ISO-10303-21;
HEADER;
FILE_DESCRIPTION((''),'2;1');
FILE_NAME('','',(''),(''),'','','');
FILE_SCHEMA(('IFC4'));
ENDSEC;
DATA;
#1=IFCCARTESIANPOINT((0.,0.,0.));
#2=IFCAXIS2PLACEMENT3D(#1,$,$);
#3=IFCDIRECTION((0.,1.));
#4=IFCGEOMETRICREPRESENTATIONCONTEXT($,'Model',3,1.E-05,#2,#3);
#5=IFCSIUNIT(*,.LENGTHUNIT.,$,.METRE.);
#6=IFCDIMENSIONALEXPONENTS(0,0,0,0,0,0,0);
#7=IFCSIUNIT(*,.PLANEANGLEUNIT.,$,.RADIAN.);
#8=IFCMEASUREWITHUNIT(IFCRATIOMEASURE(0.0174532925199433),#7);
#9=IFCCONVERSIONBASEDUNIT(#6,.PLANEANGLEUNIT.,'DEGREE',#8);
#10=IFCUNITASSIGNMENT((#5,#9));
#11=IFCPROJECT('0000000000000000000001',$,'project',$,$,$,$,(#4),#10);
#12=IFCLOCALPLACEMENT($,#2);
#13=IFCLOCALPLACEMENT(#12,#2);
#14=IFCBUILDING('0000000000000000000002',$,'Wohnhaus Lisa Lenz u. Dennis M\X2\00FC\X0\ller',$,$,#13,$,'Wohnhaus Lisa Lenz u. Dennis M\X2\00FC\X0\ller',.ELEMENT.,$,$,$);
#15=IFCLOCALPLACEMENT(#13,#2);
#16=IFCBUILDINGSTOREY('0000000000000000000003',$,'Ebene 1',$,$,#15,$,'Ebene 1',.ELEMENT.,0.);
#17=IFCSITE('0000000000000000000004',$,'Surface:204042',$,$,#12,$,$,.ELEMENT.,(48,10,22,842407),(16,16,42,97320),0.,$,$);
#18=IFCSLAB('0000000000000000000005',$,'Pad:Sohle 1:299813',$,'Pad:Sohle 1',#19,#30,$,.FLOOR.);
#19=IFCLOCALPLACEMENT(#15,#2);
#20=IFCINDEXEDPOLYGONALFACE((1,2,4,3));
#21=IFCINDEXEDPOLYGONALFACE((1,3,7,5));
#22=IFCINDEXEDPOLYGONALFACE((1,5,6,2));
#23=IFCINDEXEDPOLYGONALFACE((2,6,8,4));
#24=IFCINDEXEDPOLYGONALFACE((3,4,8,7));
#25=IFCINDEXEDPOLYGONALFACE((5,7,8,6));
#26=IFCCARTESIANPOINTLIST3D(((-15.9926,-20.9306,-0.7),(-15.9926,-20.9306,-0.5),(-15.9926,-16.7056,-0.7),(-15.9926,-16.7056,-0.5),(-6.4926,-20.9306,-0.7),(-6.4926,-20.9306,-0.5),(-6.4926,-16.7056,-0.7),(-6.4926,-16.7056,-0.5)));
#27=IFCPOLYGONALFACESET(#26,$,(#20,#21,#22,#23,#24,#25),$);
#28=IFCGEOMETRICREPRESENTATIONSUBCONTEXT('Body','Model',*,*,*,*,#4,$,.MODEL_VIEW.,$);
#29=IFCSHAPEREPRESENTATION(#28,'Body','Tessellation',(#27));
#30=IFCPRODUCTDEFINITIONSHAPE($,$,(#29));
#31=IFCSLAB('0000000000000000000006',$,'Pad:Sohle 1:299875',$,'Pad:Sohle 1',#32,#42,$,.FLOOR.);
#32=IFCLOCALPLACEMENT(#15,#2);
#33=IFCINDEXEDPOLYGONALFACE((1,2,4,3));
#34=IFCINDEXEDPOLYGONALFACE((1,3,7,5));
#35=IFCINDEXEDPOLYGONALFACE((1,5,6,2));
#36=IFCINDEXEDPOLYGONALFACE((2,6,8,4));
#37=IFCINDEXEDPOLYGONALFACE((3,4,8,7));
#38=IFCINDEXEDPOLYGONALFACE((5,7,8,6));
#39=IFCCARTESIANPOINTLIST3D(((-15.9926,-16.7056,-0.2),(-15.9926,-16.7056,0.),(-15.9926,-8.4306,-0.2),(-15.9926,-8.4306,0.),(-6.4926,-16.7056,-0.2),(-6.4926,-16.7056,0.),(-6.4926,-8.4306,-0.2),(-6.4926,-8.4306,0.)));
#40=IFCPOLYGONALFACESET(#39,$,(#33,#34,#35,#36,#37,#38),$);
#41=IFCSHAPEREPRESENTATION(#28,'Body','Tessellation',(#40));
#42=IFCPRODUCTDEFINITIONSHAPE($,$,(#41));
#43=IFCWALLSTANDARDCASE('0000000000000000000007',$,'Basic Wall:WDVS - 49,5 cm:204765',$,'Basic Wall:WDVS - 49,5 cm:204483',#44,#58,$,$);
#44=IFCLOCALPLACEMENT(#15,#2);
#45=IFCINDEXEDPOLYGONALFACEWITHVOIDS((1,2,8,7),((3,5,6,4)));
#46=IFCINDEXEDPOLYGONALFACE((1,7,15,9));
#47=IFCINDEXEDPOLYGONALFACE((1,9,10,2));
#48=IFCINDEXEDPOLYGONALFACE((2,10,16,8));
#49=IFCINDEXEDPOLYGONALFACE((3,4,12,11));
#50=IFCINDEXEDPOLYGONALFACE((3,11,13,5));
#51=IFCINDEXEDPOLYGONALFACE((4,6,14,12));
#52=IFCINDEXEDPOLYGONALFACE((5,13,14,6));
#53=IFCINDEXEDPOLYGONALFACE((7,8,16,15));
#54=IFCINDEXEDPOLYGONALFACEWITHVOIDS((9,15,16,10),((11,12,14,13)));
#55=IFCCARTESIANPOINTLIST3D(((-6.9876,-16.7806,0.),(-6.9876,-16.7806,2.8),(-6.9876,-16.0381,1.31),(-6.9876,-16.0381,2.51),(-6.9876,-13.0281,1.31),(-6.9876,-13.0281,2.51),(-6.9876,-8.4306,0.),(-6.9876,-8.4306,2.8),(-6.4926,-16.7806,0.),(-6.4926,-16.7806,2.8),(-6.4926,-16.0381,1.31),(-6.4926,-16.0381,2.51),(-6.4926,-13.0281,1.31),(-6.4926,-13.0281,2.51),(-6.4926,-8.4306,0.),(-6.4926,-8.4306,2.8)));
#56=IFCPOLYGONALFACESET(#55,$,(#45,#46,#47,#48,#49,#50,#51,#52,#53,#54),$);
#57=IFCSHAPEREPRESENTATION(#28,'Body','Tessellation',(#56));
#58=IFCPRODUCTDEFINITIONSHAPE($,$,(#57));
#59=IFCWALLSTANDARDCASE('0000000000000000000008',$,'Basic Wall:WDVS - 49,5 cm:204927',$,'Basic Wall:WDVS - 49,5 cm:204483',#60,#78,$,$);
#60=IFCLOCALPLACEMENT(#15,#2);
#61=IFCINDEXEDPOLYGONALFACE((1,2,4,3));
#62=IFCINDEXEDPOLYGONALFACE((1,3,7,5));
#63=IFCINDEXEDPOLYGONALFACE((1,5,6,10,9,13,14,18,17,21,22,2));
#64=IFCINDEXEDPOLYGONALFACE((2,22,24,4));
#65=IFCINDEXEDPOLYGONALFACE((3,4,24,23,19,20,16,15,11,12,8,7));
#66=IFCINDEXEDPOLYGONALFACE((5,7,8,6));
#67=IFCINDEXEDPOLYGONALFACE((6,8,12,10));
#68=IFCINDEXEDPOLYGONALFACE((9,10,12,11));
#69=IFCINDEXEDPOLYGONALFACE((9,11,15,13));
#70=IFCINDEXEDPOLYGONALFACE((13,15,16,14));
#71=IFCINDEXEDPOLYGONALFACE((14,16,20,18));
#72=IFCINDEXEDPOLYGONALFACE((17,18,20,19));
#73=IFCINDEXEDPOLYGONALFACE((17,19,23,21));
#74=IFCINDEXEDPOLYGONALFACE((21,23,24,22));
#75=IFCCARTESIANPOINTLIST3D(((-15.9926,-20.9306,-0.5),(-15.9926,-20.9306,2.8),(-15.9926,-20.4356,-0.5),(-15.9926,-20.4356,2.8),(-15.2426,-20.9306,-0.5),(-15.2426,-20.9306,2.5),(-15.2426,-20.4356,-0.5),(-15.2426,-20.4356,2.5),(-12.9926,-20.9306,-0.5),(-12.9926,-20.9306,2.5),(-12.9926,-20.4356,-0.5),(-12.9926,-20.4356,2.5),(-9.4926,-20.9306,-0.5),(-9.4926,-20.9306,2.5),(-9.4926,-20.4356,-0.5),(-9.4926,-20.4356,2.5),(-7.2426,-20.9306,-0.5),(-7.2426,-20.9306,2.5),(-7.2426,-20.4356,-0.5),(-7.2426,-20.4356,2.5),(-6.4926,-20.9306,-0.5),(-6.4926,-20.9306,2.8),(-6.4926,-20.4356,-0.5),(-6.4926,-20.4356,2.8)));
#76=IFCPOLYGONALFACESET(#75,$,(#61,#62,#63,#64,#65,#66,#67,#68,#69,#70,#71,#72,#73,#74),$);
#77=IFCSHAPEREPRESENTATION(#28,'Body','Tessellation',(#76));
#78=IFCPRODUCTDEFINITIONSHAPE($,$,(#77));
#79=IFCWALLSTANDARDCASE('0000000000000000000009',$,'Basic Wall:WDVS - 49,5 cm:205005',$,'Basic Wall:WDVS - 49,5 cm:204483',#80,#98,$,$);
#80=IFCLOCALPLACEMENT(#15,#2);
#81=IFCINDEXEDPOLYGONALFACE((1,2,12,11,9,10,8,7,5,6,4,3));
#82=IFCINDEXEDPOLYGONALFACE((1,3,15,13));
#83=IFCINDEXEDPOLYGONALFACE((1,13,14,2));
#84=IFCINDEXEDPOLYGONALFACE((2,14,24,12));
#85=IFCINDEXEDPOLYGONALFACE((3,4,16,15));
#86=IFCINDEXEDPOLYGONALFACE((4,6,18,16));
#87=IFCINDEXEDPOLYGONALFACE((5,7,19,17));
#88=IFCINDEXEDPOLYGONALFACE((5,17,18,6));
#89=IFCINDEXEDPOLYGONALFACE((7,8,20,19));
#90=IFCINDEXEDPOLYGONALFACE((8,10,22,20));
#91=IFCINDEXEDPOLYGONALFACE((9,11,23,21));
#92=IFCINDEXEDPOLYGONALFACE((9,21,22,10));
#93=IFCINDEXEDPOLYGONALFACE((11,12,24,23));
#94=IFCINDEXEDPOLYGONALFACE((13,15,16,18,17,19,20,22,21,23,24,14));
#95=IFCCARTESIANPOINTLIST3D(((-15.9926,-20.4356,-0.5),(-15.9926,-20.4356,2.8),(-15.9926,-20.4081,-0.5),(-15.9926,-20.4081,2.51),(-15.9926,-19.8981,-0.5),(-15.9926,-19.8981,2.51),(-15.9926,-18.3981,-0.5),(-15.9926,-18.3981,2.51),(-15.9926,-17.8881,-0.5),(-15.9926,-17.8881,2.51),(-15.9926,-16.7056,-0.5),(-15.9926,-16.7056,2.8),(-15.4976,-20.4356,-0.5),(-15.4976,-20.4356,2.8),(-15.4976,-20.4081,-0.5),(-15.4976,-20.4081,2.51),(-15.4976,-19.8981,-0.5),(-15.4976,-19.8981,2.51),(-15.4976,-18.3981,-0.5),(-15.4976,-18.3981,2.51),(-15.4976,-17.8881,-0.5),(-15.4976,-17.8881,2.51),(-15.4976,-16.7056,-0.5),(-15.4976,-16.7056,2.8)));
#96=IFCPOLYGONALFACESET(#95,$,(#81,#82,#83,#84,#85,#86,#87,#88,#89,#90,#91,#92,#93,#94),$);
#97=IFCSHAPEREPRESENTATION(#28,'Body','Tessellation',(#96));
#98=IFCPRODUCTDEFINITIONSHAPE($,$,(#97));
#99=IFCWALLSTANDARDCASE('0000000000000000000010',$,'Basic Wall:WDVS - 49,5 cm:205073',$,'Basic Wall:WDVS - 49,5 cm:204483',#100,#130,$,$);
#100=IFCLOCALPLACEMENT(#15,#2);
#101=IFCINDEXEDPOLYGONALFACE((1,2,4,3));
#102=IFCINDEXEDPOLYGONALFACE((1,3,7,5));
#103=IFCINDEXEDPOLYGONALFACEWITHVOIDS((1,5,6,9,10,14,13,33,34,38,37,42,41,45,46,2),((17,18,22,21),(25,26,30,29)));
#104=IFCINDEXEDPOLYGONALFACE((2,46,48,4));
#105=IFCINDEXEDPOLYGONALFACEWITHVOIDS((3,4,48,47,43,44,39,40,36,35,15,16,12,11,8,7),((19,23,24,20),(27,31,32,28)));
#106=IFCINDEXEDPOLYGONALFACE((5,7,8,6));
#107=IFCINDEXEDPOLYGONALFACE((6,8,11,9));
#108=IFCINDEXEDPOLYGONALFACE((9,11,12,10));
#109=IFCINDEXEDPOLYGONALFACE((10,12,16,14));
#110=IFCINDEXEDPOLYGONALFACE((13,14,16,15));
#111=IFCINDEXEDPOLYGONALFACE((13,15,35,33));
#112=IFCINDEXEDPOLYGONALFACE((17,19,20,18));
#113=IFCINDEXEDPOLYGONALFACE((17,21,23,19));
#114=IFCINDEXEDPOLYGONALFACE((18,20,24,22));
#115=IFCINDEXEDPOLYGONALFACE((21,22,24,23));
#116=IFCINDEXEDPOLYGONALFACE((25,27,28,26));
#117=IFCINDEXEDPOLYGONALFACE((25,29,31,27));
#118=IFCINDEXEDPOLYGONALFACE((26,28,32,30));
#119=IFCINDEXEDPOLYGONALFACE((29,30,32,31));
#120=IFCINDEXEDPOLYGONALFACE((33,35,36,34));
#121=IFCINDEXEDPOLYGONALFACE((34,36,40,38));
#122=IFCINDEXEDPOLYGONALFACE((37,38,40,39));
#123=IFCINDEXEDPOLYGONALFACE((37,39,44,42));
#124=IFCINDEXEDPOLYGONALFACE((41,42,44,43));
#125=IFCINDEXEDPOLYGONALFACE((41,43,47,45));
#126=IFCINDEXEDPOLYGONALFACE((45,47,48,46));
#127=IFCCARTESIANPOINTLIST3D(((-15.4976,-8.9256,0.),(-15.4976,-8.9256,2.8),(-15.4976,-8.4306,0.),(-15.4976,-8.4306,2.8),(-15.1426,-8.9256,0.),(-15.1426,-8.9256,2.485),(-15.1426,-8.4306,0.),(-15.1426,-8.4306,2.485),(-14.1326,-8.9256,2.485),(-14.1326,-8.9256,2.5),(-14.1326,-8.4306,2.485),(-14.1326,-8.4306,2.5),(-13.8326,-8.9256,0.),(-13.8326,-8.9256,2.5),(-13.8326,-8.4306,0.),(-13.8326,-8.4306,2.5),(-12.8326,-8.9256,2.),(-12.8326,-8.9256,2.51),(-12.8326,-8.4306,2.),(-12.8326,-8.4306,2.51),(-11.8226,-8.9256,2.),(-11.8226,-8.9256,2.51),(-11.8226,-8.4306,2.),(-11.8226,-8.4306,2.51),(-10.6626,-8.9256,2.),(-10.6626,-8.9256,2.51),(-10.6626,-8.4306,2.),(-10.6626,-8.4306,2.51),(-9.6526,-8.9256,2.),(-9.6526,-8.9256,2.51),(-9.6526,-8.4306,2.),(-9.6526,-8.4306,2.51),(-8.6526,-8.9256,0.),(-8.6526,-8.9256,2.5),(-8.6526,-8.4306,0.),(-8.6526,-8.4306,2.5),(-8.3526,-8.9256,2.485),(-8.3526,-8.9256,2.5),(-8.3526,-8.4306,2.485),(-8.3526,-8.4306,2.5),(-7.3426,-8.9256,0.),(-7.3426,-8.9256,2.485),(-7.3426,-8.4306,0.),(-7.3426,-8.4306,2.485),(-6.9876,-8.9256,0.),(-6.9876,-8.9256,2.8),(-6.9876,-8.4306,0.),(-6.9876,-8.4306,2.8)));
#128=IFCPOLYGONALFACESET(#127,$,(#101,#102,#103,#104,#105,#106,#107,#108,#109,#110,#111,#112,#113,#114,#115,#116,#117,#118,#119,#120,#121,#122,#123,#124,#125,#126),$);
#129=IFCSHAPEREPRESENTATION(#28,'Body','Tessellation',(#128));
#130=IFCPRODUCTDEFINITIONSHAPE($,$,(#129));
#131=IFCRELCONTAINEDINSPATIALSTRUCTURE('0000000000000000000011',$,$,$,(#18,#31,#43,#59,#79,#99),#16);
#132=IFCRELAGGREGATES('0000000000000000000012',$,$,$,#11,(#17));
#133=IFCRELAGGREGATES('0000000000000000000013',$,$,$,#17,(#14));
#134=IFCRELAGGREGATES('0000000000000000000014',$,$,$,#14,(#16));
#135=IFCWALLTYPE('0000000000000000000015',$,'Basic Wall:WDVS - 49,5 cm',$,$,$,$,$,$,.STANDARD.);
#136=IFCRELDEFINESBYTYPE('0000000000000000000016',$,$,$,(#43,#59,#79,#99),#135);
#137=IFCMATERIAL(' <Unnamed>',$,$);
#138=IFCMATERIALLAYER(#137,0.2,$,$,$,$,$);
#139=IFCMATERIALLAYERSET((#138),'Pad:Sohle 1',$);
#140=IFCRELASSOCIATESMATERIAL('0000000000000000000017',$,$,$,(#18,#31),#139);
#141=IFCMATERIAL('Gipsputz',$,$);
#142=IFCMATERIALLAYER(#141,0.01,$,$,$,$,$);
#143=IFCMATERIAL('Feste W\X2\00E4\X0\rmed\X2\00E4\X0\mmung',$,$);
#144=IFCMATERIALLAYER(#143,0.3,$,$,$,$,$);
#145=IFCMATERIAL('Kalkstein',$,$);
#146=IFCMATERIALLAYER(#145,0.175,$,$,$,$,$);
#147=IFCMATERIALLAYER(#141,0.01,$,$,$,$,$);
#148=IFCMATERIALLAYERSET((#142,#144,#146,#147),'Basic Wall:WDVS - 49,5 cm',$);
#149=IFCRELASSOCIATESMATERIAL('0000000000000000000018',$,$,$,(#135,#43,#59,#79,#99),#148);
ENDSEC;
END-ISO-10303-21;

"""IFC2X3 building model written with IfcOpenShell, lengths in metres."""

from ifc_helpers import new_model, entity, si_unit, converted_unit, direction, frame, frame_2d, origin, place, context, subcontext, project, spatial, polyline, rectangle, extrude, clip, bounded_halfspace, material, layer, layer_set, layer_usage, type_object, element, save


model = new_model("IFC2X3")

# Units and contexts
model_context = context("Model", 3, precision=1e-05, world=origin(), true_north=direction((0.0, 1.0)))
body_context = subcontext(model_context, "Body", "Model", "MODEL_VIEW")
ifc_project = project(units=[si_unit("LENGTHUNIT", "METRE"), converted_unit("PLANEANGLEUNIT", "DEGREE", entity("IfcRatioMeasure", 0.0174532925199433), si_unit("PLANEANGLEUNIT", "RADIAN"), dimensions=[0, 0, 0, 0, 0, 0, 0])], contexts=[model_context])

# Site, building, storey
site_placement = place(None, origin())
site = spatial("IfcSite", under=ifc_project, at=site_placement, Name="Surface:204042", CompositionType="ELEMENT", RefLatitude=(48, 10, 22, 842407), RefLongitude=(16, 16, 42, 97320), RefElevation=0.0)
building_placement = place(site_placement, origin())
building = spatial("IfcBuilding", under=site, at=building_placement, Name="Wohnhaus Lisa Lenz u. Dennis Müller", LongName="Wohnhaus Lisa Lenz u. Dennis Müller", CompositionType="ELEMENT")
storey_placement = place(building_placement, origin())
storey = spatial("IfcBuildingStorey", under=building, at=storey_placement, Name="Ebene 1", LongName="Ebene 1", CompositionType="ELEMENT", Elevation=0.0)

# Slabs
ifc_material_1 = material(Name=" <Unnamed>")
ifc_layer_1 = layer(ifc_material_1, 0.2)
ifc_layer_set_1 = layer_set([ifc_layer_1], Name="Pad:Sohle 1")
ifc_layer_usage_1 = layer_usage(ifc_layer_set_1, "AXIS3", "POSITIVE", 0.0)
slab_1_placement = place(storey_placement, origin())
element("IfcSlab", 1, at=slab_1_placement, inside=storey, material=ifc_layer_usage_1, Name="Pad:Sohle 1:299813", ObjectType="Pad:Sohle 1", PredefinedType="FLOOR", context=body_context, shape_type="SweptSolid", body=[
    extrude(rectangle(XDim=9.5, YDim=4.225, at=frame_2d((0.0, 0.0), x_axis=(1.0, 0.0))), frame((-11.2426, -18.8181, -0.7), z_axis=(0.0, 0.0, 1.0), x_axis=(-1.0, 0.0, 0.0)), (0.0, 0.0, 1.0), 0.2),
])
ifc_layer_usage_2 = layer_usage(ifc_layer_set_1, "AXIS3", "POSITIVE", 0.0)
slab_2_placement = place(storey_placement, origin())
element("IfcSlab", 2, at=slab_2_placement, inside=storey, material=ifc_layer_usage_2, Name="Pad:Sohle 1:299875", ObjectType="Pad:Sohle 1", PredefinedType="FLOOR", context=body_context, shape_type="SweptSolid", body=[
    extrude(rectangle(XDim=9.5, YDim=8.275, at=frame_2d((0.0, 0.0), x_axis=(1.0, 0.0))), frame((-11.2426, -12.5681, -0.2), z_axis=(0.0, 0.0, 1.0), x_axis=(-1.0, 0.0, 0.0)), (0.0, 0.0, 1.0), 0.2),
])

# Wall, opening
ifc_material_2 = material(Name="Gipsputz")
ifc_layer_2 = layer(ifc_material_2, 0.01)
ifc_material_3 = material(Name="Feste Wärmedämmung")
ifc_layer_3 = layer(ifc_material_3, 0.3)
ifc_material_4 = material(Name="Kalkstein")
ifc_layer_4 = layer(ifc_material_4, 0.175)
ifc_layer_5 = layer(ifc_material_2, 0.01)
ifc_layer_set_2 = layer_set([ifc_layer_2, ifc_layer_3, ifc_layer_4, ifc_layer_5], Name="Basic Wall:WDVS - 49,5 cm")
ifc_layer_usage_3 = layer_usage(ifc_layer_set_2, "AXIS2", "NEGATIVE", 0.2475)
wall_type_1 = type_object("IfcWallType", Name="Basic Wall:WDVS - 49,5 cm", PredefinedType="STANDARD", material=ifc_layer_set_2)
wall_1_placement = place(storey_placement, frame((-6.7401, -8.4306, 0.0), z_axis=(0.0, 0.0, 1.0), x_axis=(0.0, -1.0, 0.0)))
wall_1 = element("IfcWallStandardCase", 3, at=wall_1_placement, inside=storey, type_object=wall_type_1, material=ifc_layer_usage_3, Name="Basic Wall:WDVS - 49,5 cm:204765", ObjectType="Basic Wall:WDVS - 49,5 cm:204483", context=body_context, shape_type="Clipping", body=[
    clip(extrude(rectangle(XDim=8.35, YDim=0.495, at=frame_2d((4.175, 0.0), x_axis=(-1.0, 0.0))), origin(), (0.0, 0.0, 1.0), 2.8), bounded_halfspace(frame((0.0, -0.2475, 2.8), z_axis=(0.0, 0.0, -1.0), x_axis=(0.0, -1.0, 0.0)), True, frame((0.0, -0.2475, 2.8)), polyline([(0.0, 0.0), (0.495, 0.0), (8.35, 0.0), (8.35, 0.495), (0.0, 0.495), (0.0, 0.0)]))),
])
opening_1_placement = place(wall_1_placement, frame((7.6075, 0.2475, 1.31)))
element("IfcOpeningElement", 4, at=opening_1_placement, cuts=wall_1, ObjectType="Opening", context=body_context, shape_type="SweptSolid", body=[
    extrude(rectangle(XDim=1.2, YDim=3.01, at=frame_2d((0.6, 1.505), x_axis=(1.0, 0.0))), frame((0.0, 0.0, 0.0), z_axis=(0.0, -1.0, 0.0), x_axis=(0.0, 0.0, 1.0)), (0.0, 0.0, 1.0), 0.495),
])

# Walls, openings
ifc_layer_usage_4 = layer_usage(ifc_layer_set_2, "AXIS2", "NEGATIVE", 0.2475)
wall_2_placement = place(storey_placement, frame((-6.4926, -20.6831, -0.5), z_axis=(0.0, 0.0, 1.0), x_axis=(-1.0, 0.0, 0.0)))
wall_2 = element("IfcWallStandardCase", 5, at=wall_2_placement, inside=storey, type_object=wall_type_1, material=ifc_layer_usage_4, Name="Basic Wall:WDVS - 49,5 cm:204927", ObjectType="Basic Wall:WDVS - 49,5 cm:204483", context=body_context, shape_type="Clipping", body=[
    clip(extrude(rectangle(XDim=9.5, YDim=0.495, at=frame_2d((4.75, 0.0), x_axis=(-1.0, 0.0))), origin(), (0.0, 0.0, 1.0), 3.3), bounded_halfspace(frame((0.0, -0.2475, 3.3), z_axis=(0.0, 0.0, -1.0), x_axis=(1.0, 0.0, 0.0)), True, frame((0.0, -0.2475, 3.3)), polyline([(0.0, 0.0), (0.495, 0.0), (4.5, 0.0), (5.0, 0.0), (9.005, 0.0), (9.5, 0.0), (9.5, 0.495), (0.0, 0.495), (0.0, 0.0)]))),
])
opening_2_placement = place(wall_2_placement, frame((8.75, 0.2475, 0.0)))
element("IfcOpeningElement", 6, at=opening_2_placement, cuts=wall_2, ObjectType="Opening", context=body_context, shape_type="SweptSolid", body=[
    extrude(rectangle(XDim=3.0, YDim=2.25, at=frame_2d((1.5, 1.125), x_axis=(1.0, 0.0))), frame((0.0, 0.0, 0.0), z_axis=(0.0, -1.0, 0.0), x_axis=(0.0, 0.0, 1.0)), (0.0, 0.0, 1.0), 0.495),
])
opening_3_placement = place(wall_2_placement, frame((3.0, 0.2475, 0.0)))
element("IfcOpeningElement", 7, at=opening_3_placement, cuts=wall_2, ObjectType="Opening", context=body_context, shape_type="SweptSolid", body=[
    extrude(rectangle(XDim=3.0, YDim=2.25, at=frame_2d((1.5, 1.125), x_axis=(1.0, 0.0))), frame((0.0, 0.0, 0.0), z_axis=(0.0, -1.0, 0.0), x_axis=(0.0, 0.0, 1.0)), (0.0, 0.0, 1.0), 0.495),
])
ifc_layer_usage_5 = layer_usage(ifc_layer_set_2, "AXIS2", "NEGATIVE", 0.2475)
wall_3_placement = place(storey_placement, frame((-15.7451, -20.4356, -0.5), z_axis=(0.0, 0.0, 1.0), x_axis=(0.0, 1.0, 0.0)))
wall_3 = element("IfcWallStandardCase", 8, at=wall_3_placement, inside=storey, type_object=wall_type_1, material=ifc_layer_usage_5, Name="Basic Wall:WDVS - 49,5 cm:205005", ObjectType="Basic Wall:WDVS - 49,5 cm:204483", context=body_context, shape_type="Clipping", body=[
    clip(extrude(rectangle(XDim=3.73, YDim=0.495, at=frame_2d((1.865, 0.0), x_axis=(-1.0, 0.0))), origin(), (0.0, 0.0, 1.0), 3.3), bounded_halfspace(frame((0.0, -0.2475, 3.3), z_axis=(0.0, 0.0, -1.0), x_axis=(0.0, 1.0, 0.0)), True, frame((0.0, -0.2475, 3.3)), polyline([(0.0, 0.0), (3.655, 0.0), (3.655, 0.495), (0.0, 0.495), (0.0, 0.0)]))),
])
opening_4_placement = place(wall_3_placement, frame((2.5475, 0.2475, 0.0)))
element("IfcOpeningElement", 9, at=opening_4_placement, cuts=wall_3, ObjectType="Opening", context=body_context, shape_type="SweptSolid", body=[
    extrude(rectangle(XDim=3.01, YDim=0.51, at=frame_2d((1.505, 0.255), x_axis=(1.0, 0.0))), frame((0.0, 0.0, 0.0), z_axis=(0.0, -1.0, 0.0), x_axis=(0.0, 0.0, 1.0)), (0.0, 0.0, 1.0), 0.495),
])
opening_5_placement = place(wall_3_placement, frame((0.5375, 0.2475, 0.0)))
element("IfcOpeningElement", 10, at=opening_5_placement, cuts=wall_3, ObjectType="Opening", context=body_context, shape_type="SweptSolid", body=[
    extrude(rectangle(XDim=3.01, YDim=0.51, at=frame_2d((1.505, 0.255), x_axis=(1.0, 0.0))), frame((0.0, 0.0, 0.0), z_axis=(0.0, -1.0, 0.0), x_axis=(0.0, 0.0, 1.0)), (0.0, 0.0, 1.0), 0.495),
])
ifc_layer_usage_6 = layer_usage(ifc_layer_set_2, "AXIS2", "NEGATIVE", 0.2475)
wall_4_placement = place(storey_placement, frame((-15.4976, -8.6781, 0.0)))
wall_4 = element("IfcWallStandardCase", 11, at=wall_4_placement, inside=storey, type_object=wall_type_1, material=ifc_layer_usage_6, Name="Basic Wall:WDVS - 49,5 cm:205073", ObjectType="Basic Wall:WDVS - 49,5 cm:204483", context=body_context, shape_type="Clipping", body=[
    clip(extrude(rectangle(XDim=8.51, YDim=0.495, at=frame_2d((4.255, 0.0), x_axis=(-1.0, 0.0))), origin(), (0.0, 0.0, 1.0), 2.8), bounded_halfspace(frame((0.0, -0.2475, 2.8), z_axis=(0.0, 0.0, -1.0), x_axis=(-1.0, 0.0, 0.0)), True, frame((0.0, -0.2475, 2.8)), polyline([(0.0, 0.0), (2.305, 0.0), (2.455, 0.0), (4.005, 0.0), (4.505, 0.0), (6.055, 0.0), (6.205, 0.0), (8.51, 0.0), (8.51, 0.495), (0.0, 0.495), (0.0, 0.0)]))),
])
opening_6_placement = place(wall_4_placement, frame((8.155, 0.2475, 0.0)))
element("IfcOpeningElement", 12, at=opening_6_placement, cuts=wall_4, ObjectType="Opening", context=body_context, shape_type="SweptSolid", body=[
    extrude(rectangle(XDim=2.485, YDim=1.01, at=frame_2d((1.2425, 0.505), x_axis=(1.0, 0.0))), frame((0.0, 0.0, 0.0), z_axis=(0.0, -1.0, 0.0), x_axis=(0.0, 0.0, 1.0)), (0.0, 0.0, 1.0), 0.495),
])
opening_7_placement = place(wall_4_placement, frame((7.145, 0.2475, 0.0)))
element("IfcOpeningElement", 13, at=opening_7_placement, cuts=wall_4, ObjectType="Opening", context=body_context, shape_type="SweptSolid", body=[
    extrude(rectangle(XDim=2.5, YDim=0.3, at=frame_2d((1.25, 0.15), x_axis=(1.0, 0.0))), frame((0.0, 0.0, 0.0), z_axis=(0.0, -1.0, 0.0), x_axis=(0.0, 0.0, 1.0)), (0.0, 0.0, 1.0), 0.495),
])
opening_8_placement = place(wall_4_placement, frame((1.665, 0.2475, 0.0)))
element("IfcOpeningElement", 14, at=opening_8_placement, cuts=wall_4, ObjectType="Opening", context=body_context, shape_type="SweptSolid", body=[
    extrude(rectangle(XDim=2.5, YDim=0.3, at=frame_2d((1.25, 0.15), x_axis=(1.0, 0.0))), frame((0.0, 0.0, 0.0), z_axis=(0.0, -1.0, 0.0), x_axis=(0.0, 0.0, 1.0)), (0.0, 0.0, 1.0), 0.495),
])
opening_9_placement = place(wall_4_placement, frame((1.365, 0.2475, 0.0)))
element("IfcOpeningElement", 15, at=opening_9_placement, cuts=wall_4, ObjectType="Opening", context=body_context, shape_type="SweptSolid", body=[
    extrude(rectangle(XDim=2.485, YDim=1.01, at=frame_2d((1.2425, 0.505), x_axis=(1.0, 0.0))), frame((0.0, 0.0, 0.0), z_axis=(0.0, -1.0, 0.0), x_axis=(0.0, 0.0, 1.0)), (0.0, 0.0, 1.0), 0.495),
])
opening_10_placement = place(wall_4_placement, frame((5.845, 0.2475, 2.0)))
element("IfcOpeningElement", 16, at=opening_10_placement, cuts=wall_4, ObjectType="Opening", context=body_context, shape_type="SweptSolid", body=[
    extrude(rectangle(XDim=0.51, YDim=1.01, at=frame_2d((0.255, 0.505), x_axis=(1.0, 0.0))), frame((0.0, 0.0, 0.0), z_axis=(0.0, -1.0, 0.0), x_axis=(0.0, 0.0, 1.0)), (0.0, 0.0, 1.0), 0.495),
])
opening_11_placement = place(wall_4_placement, frame((3.675, 0.2475, 2.0)))
element("IfcOpeningElement", 17, at=opening_11_placement, cuts=wall_4, ObjectType="Opening", context=body_context, shape_type="SweptSolid", body=[
    extrude(rectangle(XDim=0.51, YDim=1.01, at=frame_2d((0.255, 0.505), x_axis=(1.0, 0.0))), frame((0.0, 0.0, 0.0), z_axis=(0.0, -1.0, 0.0), x_axis=(0.0, 0.0, 1.0)), (0.0, 0.0, 1.0), 0.495),
])

save(model, "model.ifc")
